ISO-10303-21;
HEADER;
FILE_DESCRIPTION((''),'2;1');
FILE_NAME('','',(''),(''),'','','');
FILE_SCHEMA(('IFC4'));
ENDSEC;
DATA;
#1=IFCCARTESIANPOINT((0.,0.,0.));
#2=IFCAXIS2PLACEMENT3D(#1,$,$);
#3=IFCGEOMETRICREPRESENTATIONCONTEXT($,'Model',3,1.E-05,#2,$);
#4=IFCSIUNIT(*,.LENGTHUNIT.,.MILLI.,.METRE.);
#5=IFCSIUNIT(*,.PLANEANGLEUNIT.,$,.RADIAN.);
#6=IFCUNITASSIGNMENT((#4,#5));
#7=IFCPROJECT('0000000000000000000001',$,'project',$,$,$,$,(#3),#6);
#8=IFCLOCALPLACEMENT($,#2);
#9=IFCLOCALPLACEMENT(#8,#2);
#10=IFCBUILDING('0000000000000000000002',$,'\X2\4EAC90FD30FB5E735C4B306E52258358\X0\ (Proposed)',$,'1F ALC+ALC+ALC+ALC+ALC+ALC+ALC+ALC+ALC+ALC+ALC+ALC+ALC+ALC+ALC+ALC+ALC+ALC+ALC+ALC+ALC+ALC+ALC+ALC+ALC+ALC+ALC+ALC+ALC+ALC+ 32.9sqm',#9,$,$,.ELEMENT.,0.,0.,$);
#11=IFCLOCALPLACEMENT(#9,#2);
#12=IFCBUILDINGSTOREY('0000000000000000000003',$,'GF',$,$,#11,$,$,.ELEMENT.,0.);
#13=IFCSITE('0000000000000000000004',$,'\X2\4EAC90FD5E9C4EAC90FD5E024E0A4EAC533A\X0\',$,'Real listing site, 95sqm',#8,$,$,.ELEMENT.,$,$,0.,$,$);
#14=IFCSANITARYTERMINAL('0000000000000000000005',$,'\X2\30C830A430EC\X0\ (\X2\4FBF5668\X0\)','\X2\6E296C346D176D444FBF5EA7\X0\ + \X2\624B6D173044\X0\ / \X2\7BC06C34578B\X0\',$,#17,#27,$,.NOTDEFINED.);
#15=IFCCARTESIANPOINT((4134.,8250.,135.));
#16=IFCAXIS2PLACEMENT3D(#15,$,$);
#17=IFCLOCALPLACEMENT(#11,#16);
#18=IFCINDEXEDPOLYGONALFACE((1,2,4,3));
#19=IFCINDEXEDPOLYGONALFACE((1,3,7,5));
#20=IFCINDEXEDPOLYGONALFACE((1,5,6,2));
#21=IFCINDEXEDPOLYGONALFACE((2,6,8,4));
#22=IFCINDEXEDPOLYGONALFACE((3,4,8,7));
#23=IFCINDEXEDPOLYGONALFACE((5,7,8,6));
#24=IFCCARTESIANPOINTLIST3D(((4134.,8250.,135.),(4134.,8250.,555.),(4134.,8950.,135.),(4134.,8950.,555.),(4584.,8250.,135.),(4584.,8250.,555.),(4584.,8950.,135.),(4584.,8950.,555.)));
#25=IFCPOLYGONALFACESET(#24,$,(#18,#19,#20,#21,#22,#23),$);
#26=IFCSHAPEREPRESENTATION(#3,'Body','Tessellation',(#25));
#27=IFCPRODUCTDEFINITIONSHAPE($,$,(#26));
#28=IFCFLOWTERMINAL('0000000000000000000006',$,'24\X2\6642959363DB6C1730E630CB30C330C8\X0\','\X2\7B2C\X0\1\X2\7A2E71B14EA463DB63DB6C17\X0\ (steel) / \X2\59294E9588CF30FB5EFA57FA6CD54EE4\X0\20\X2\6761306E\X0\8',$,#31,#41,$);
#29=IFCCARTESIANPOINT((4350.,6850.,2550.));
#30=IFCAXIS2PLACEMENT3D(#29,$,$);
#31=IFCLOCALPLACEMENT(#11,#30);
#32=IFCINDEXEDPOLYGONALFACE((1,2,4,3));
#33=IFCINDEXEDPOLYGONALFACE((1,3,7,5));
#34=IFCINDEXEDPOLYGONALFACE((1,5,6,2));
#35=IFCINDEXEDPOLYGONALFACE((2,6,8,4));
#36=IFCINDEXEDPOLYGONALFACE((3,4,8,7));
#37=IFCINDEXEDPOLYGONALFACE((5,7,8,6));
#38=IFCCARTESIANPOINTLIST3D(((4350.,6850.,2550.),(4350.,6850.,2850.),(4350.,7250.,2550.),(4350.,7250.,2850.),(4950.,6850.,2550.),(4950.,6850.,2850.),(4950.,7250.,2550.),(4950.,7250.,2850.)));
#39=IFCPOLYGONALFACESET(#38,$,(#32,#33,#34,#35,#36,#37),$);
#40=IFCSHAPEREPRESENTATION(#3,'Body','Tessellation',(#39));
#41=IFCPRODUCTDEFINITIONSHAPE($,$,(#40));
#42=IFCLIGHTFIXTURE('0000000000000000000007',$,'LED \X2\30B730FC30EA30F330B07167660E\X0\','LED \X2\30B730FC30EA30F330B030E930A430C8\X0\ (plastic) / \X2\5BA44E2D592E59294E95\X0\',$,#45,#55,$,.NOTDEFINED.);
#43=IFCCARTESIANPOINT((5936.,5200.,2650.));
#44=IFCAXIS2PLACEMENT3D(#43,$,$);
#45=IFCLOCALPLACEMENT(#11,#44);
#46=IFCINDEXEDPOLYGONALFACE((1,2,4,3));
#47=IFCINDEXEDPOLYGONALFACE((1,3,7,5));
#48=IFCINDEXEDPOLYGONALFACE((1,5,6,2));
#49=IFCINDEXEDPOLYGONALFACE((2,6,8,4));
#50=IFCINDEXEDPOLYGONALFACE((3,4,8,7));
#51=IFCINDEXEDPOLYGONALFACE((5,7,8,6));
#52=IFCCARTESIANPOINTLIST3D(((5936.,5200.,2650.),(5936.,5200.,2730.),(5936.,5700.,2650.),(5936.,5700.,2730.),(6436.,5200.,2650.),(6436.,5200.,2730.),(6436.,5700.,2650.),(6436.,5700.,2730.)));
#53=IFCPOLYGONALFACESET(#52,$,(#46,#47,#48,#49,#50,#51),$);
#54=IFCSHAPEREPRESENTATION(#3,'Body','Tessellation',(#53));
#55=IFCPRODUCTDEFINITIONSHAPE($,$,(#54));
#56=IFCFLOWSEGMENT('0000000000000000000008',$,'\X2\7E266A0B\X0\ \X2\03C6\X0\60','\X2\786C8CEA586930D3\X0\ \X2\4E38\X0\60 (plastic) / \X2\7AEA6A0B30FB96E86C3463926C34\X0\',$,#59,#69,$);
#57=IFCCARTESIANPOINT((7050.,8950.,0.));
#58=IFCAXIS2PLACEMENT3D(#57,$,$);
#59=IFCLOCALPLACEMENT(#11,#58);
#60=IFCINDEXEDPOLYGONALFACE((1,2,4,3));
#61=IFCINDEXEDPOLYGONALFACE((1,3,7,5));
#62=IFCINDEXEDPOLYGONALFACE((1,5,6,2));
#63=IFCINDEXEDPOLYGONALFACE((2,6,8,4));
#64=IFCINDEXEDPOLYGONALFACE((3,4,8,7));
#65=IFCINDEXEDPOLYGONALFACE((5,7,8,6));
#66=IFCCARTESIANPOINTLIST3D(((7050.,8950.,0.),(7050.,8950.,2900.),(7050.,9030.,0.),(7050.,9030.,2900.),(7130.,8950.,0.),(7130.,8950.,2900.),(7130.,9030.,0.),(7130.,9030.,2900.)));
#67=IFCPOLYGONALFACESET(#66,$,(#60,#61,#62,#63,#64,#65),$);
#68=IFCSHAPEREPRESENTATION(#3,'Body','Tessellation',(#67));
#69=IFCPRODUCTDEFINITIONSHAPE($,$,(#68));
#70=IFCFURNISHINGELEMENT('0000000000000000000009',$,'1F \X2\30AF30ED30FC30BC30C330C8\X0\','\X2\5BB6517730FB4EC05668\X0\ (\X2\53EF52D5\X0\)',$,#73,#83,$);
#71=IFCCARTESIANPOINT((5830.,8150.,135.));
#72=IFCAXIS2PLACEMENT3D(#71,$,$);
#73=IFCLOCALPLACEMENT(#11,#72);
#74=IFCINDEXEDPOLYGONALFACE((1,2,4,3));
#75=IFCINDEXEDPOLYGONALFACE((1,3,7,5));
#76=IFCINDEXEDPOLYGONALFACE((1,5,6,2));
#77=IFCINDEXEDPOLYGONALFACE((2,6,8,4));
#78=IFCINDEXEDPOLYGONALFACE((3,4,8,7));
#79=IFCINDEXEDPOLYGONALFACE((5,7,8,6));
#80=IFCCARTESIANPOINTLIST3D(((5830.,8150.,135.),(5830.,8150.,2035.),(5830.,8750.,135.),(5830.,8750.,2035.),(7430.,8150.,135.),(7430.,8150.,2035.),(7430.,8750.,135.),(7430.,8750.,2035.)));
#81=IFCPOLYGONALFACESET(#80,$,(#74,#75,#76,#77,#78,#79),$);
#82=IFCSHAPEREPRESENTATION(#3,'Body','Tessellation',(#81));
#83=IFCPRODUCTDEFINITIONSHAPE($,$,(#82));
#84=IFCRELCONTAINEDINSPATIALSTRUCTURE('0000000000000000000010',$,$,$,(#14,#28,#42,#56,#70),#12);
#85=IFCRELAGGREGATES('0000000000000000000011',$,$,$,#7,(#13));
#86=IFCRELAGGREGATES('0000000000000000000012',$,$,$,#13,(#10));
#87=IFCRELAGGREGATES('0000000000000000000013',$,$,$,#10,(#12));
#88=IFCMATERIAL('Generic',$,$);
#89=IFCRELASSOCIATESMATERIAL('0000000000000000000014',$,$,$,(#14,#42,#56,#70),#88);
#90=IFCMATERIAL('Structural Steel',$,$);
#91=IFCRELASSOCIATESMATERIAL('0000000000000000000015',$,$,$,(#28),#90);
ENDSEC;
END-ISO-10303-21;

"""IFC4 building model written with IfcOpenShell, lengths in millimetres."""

from ifc_helpers import new_model, si_unit, frame, frame_2d, origin, place, context, project, spatial, rectangle, extrude, material, element, save


model = new_model("IFC4")

# Units and contexts
model_context = context("Model", 3, precision=1e-05, world=origin())
ifc_project = project(units=[si_unit("LENGTHUNIT", "METRE", prefix="MILLI"), si_unit("PLANEANGLEUNIT", "RADIAN")], contexts=[model_context])

# Site, building, storey
site_placement = place(None, origin())
site = spatial("IfcSite", under=ifc_project, at=site_placement, Name="京都府京都市上京区", ObjectType="Real listing site, 95sqm", CompositionType="ELEMENT", RefElevation=0.0)
building_placement = place(site_placement, origin())
building = spatial("IfcBuilding", under=site, at=building_placement, Name="京都・平屋の別荘 (Proposed)", ObjectType="1F ALC+ALC+ALC+ALC+ALC+ALC+ALC+ALC+ALC+ALC+ALC+ALC+ALC+ALC+ALC+ALC+ALC+ALC+ALC+ALC+ALC+ALC+ALC+ALC+ALC+ALC+ALC+ALC+ALC+ALC+ 32.9sqm", CompositionType="ELEMENT", ElevationOfRefHeight=0.0, ElevationOfTerrain=0.0)
storey_placement = place(building_placement, origin())
storey = spatial("IfcBuildingStorey", under=building, at=storey_placement, Name="GF", CompositionType="ELEMENT", Elevation=0.0)

# Shared definitions
ifc_material_1 = material(Name="Generic")

# Sanitary terminal
sanitary_terminal_1_placement = place(storey_placement, frame((4134.0, 8250.0, 135.0)))
element("IfcSanitaryTerminal", 1, at=sanitary_terminal_1_placement, inside=storey, material=ifc_material_1, Name="トイレ (便器)", Description="温水洗浄便座 + 手洗い / 節水型", PredefinedType="NOTDEFINED", context=model_context, shape_type="SweptSolid", body=[
    extrude(rectangle(XDim=450.0, YDim=700.0, at=frame_2d((225.0, 350.0))), frame((4134.0, 8250.0, 135.0)), (0.0, 0.0, 1.0), 420.0),
])

# Flow terminal
ifc_material_2 = material(Name="Structural Steel")
flow_terminal_placement = place(storey_placement, frame((4350.0, 6850.0, 2550.0)))
element("IfcFlowTerminal", 2, at=flow_terminal_placement, inside=storey, material=ifc_material_2, Name="24時間換気ユニット", Description="第1種熱交換換気 (steel) / 天井裏・建基法令20条の8", context=model_context, shape_type="SweptSolid", body=[
    extrude(rectangle(XDim=600.0, YDim=400.0, at=frame_2d((300.0, 200.0))), frame((4350.0, 6850.0, 2550.0)), (0.0, 0.0, 1.0), 300.0),
])

# Light fixture
light_fixture_placement = place(storey_placement, frame((5936.0, 5200.0, 2650.0)))
element("IfcLightFixture", 3, at=light_fixture_placement, inside=storey, material=ifc_material_1, Name="LED シーリング照明", Description="LED シーリングライト (plastic) / 室中央天井", PredefinedType="NOTDEFINED", context=model_context, shape_type="SweptSolid", body=[
    extrude(rectangle(XDim=500.0, YDim=500.0, at=frame_2d((250.0, 250.0))), frame((5936.0, 5200.0, 2650.0)), (0.0, 0.0, 1.0), 80.0),
])

# Flow segment
flow_segment_placement = place(storey_placement, frame((7050.0, 8950.0, 0.0)))
element("IfcFlowSegment", 4, at=flow_segment_placement, inside=storey, material=ifc_material_1, Name="縦樋 φ60", Description="硬質塩ビ 丸60 (plastic) / 竪樋・雨水排水", context=model_context, shape_type="SweptSolid", body=[
    extrude(rectangle(XDim=80.0, YDim=80.0, at=frame_2d((40.0, 40.0))), frame((7050.0, 8950.0, 0.0)), (0.0, 0.0, 1.0), 2900.0),
])

# Furnishing element
furnishing_placement = place(storey_placement, frame((5830.0, 8150.0, 135.0)))
element("IfcFurnishingElement", 5, at=furnishing_placement, inside=storey, material=ifc_material_1, Name="1F クローゼット", Description="家具・什器 (可動)", context=model_context, shape_type="SweptSolid", body=[
    extrude(rectangle(XDim=1600.0, YDim=600.0, at=frame_2d((800.0, 300.0))), frame((5830.0, 8150.0, 135.0)), (0.0, 0.0, 1.0), 1900.0),
])

save(model, "model.ifc")
